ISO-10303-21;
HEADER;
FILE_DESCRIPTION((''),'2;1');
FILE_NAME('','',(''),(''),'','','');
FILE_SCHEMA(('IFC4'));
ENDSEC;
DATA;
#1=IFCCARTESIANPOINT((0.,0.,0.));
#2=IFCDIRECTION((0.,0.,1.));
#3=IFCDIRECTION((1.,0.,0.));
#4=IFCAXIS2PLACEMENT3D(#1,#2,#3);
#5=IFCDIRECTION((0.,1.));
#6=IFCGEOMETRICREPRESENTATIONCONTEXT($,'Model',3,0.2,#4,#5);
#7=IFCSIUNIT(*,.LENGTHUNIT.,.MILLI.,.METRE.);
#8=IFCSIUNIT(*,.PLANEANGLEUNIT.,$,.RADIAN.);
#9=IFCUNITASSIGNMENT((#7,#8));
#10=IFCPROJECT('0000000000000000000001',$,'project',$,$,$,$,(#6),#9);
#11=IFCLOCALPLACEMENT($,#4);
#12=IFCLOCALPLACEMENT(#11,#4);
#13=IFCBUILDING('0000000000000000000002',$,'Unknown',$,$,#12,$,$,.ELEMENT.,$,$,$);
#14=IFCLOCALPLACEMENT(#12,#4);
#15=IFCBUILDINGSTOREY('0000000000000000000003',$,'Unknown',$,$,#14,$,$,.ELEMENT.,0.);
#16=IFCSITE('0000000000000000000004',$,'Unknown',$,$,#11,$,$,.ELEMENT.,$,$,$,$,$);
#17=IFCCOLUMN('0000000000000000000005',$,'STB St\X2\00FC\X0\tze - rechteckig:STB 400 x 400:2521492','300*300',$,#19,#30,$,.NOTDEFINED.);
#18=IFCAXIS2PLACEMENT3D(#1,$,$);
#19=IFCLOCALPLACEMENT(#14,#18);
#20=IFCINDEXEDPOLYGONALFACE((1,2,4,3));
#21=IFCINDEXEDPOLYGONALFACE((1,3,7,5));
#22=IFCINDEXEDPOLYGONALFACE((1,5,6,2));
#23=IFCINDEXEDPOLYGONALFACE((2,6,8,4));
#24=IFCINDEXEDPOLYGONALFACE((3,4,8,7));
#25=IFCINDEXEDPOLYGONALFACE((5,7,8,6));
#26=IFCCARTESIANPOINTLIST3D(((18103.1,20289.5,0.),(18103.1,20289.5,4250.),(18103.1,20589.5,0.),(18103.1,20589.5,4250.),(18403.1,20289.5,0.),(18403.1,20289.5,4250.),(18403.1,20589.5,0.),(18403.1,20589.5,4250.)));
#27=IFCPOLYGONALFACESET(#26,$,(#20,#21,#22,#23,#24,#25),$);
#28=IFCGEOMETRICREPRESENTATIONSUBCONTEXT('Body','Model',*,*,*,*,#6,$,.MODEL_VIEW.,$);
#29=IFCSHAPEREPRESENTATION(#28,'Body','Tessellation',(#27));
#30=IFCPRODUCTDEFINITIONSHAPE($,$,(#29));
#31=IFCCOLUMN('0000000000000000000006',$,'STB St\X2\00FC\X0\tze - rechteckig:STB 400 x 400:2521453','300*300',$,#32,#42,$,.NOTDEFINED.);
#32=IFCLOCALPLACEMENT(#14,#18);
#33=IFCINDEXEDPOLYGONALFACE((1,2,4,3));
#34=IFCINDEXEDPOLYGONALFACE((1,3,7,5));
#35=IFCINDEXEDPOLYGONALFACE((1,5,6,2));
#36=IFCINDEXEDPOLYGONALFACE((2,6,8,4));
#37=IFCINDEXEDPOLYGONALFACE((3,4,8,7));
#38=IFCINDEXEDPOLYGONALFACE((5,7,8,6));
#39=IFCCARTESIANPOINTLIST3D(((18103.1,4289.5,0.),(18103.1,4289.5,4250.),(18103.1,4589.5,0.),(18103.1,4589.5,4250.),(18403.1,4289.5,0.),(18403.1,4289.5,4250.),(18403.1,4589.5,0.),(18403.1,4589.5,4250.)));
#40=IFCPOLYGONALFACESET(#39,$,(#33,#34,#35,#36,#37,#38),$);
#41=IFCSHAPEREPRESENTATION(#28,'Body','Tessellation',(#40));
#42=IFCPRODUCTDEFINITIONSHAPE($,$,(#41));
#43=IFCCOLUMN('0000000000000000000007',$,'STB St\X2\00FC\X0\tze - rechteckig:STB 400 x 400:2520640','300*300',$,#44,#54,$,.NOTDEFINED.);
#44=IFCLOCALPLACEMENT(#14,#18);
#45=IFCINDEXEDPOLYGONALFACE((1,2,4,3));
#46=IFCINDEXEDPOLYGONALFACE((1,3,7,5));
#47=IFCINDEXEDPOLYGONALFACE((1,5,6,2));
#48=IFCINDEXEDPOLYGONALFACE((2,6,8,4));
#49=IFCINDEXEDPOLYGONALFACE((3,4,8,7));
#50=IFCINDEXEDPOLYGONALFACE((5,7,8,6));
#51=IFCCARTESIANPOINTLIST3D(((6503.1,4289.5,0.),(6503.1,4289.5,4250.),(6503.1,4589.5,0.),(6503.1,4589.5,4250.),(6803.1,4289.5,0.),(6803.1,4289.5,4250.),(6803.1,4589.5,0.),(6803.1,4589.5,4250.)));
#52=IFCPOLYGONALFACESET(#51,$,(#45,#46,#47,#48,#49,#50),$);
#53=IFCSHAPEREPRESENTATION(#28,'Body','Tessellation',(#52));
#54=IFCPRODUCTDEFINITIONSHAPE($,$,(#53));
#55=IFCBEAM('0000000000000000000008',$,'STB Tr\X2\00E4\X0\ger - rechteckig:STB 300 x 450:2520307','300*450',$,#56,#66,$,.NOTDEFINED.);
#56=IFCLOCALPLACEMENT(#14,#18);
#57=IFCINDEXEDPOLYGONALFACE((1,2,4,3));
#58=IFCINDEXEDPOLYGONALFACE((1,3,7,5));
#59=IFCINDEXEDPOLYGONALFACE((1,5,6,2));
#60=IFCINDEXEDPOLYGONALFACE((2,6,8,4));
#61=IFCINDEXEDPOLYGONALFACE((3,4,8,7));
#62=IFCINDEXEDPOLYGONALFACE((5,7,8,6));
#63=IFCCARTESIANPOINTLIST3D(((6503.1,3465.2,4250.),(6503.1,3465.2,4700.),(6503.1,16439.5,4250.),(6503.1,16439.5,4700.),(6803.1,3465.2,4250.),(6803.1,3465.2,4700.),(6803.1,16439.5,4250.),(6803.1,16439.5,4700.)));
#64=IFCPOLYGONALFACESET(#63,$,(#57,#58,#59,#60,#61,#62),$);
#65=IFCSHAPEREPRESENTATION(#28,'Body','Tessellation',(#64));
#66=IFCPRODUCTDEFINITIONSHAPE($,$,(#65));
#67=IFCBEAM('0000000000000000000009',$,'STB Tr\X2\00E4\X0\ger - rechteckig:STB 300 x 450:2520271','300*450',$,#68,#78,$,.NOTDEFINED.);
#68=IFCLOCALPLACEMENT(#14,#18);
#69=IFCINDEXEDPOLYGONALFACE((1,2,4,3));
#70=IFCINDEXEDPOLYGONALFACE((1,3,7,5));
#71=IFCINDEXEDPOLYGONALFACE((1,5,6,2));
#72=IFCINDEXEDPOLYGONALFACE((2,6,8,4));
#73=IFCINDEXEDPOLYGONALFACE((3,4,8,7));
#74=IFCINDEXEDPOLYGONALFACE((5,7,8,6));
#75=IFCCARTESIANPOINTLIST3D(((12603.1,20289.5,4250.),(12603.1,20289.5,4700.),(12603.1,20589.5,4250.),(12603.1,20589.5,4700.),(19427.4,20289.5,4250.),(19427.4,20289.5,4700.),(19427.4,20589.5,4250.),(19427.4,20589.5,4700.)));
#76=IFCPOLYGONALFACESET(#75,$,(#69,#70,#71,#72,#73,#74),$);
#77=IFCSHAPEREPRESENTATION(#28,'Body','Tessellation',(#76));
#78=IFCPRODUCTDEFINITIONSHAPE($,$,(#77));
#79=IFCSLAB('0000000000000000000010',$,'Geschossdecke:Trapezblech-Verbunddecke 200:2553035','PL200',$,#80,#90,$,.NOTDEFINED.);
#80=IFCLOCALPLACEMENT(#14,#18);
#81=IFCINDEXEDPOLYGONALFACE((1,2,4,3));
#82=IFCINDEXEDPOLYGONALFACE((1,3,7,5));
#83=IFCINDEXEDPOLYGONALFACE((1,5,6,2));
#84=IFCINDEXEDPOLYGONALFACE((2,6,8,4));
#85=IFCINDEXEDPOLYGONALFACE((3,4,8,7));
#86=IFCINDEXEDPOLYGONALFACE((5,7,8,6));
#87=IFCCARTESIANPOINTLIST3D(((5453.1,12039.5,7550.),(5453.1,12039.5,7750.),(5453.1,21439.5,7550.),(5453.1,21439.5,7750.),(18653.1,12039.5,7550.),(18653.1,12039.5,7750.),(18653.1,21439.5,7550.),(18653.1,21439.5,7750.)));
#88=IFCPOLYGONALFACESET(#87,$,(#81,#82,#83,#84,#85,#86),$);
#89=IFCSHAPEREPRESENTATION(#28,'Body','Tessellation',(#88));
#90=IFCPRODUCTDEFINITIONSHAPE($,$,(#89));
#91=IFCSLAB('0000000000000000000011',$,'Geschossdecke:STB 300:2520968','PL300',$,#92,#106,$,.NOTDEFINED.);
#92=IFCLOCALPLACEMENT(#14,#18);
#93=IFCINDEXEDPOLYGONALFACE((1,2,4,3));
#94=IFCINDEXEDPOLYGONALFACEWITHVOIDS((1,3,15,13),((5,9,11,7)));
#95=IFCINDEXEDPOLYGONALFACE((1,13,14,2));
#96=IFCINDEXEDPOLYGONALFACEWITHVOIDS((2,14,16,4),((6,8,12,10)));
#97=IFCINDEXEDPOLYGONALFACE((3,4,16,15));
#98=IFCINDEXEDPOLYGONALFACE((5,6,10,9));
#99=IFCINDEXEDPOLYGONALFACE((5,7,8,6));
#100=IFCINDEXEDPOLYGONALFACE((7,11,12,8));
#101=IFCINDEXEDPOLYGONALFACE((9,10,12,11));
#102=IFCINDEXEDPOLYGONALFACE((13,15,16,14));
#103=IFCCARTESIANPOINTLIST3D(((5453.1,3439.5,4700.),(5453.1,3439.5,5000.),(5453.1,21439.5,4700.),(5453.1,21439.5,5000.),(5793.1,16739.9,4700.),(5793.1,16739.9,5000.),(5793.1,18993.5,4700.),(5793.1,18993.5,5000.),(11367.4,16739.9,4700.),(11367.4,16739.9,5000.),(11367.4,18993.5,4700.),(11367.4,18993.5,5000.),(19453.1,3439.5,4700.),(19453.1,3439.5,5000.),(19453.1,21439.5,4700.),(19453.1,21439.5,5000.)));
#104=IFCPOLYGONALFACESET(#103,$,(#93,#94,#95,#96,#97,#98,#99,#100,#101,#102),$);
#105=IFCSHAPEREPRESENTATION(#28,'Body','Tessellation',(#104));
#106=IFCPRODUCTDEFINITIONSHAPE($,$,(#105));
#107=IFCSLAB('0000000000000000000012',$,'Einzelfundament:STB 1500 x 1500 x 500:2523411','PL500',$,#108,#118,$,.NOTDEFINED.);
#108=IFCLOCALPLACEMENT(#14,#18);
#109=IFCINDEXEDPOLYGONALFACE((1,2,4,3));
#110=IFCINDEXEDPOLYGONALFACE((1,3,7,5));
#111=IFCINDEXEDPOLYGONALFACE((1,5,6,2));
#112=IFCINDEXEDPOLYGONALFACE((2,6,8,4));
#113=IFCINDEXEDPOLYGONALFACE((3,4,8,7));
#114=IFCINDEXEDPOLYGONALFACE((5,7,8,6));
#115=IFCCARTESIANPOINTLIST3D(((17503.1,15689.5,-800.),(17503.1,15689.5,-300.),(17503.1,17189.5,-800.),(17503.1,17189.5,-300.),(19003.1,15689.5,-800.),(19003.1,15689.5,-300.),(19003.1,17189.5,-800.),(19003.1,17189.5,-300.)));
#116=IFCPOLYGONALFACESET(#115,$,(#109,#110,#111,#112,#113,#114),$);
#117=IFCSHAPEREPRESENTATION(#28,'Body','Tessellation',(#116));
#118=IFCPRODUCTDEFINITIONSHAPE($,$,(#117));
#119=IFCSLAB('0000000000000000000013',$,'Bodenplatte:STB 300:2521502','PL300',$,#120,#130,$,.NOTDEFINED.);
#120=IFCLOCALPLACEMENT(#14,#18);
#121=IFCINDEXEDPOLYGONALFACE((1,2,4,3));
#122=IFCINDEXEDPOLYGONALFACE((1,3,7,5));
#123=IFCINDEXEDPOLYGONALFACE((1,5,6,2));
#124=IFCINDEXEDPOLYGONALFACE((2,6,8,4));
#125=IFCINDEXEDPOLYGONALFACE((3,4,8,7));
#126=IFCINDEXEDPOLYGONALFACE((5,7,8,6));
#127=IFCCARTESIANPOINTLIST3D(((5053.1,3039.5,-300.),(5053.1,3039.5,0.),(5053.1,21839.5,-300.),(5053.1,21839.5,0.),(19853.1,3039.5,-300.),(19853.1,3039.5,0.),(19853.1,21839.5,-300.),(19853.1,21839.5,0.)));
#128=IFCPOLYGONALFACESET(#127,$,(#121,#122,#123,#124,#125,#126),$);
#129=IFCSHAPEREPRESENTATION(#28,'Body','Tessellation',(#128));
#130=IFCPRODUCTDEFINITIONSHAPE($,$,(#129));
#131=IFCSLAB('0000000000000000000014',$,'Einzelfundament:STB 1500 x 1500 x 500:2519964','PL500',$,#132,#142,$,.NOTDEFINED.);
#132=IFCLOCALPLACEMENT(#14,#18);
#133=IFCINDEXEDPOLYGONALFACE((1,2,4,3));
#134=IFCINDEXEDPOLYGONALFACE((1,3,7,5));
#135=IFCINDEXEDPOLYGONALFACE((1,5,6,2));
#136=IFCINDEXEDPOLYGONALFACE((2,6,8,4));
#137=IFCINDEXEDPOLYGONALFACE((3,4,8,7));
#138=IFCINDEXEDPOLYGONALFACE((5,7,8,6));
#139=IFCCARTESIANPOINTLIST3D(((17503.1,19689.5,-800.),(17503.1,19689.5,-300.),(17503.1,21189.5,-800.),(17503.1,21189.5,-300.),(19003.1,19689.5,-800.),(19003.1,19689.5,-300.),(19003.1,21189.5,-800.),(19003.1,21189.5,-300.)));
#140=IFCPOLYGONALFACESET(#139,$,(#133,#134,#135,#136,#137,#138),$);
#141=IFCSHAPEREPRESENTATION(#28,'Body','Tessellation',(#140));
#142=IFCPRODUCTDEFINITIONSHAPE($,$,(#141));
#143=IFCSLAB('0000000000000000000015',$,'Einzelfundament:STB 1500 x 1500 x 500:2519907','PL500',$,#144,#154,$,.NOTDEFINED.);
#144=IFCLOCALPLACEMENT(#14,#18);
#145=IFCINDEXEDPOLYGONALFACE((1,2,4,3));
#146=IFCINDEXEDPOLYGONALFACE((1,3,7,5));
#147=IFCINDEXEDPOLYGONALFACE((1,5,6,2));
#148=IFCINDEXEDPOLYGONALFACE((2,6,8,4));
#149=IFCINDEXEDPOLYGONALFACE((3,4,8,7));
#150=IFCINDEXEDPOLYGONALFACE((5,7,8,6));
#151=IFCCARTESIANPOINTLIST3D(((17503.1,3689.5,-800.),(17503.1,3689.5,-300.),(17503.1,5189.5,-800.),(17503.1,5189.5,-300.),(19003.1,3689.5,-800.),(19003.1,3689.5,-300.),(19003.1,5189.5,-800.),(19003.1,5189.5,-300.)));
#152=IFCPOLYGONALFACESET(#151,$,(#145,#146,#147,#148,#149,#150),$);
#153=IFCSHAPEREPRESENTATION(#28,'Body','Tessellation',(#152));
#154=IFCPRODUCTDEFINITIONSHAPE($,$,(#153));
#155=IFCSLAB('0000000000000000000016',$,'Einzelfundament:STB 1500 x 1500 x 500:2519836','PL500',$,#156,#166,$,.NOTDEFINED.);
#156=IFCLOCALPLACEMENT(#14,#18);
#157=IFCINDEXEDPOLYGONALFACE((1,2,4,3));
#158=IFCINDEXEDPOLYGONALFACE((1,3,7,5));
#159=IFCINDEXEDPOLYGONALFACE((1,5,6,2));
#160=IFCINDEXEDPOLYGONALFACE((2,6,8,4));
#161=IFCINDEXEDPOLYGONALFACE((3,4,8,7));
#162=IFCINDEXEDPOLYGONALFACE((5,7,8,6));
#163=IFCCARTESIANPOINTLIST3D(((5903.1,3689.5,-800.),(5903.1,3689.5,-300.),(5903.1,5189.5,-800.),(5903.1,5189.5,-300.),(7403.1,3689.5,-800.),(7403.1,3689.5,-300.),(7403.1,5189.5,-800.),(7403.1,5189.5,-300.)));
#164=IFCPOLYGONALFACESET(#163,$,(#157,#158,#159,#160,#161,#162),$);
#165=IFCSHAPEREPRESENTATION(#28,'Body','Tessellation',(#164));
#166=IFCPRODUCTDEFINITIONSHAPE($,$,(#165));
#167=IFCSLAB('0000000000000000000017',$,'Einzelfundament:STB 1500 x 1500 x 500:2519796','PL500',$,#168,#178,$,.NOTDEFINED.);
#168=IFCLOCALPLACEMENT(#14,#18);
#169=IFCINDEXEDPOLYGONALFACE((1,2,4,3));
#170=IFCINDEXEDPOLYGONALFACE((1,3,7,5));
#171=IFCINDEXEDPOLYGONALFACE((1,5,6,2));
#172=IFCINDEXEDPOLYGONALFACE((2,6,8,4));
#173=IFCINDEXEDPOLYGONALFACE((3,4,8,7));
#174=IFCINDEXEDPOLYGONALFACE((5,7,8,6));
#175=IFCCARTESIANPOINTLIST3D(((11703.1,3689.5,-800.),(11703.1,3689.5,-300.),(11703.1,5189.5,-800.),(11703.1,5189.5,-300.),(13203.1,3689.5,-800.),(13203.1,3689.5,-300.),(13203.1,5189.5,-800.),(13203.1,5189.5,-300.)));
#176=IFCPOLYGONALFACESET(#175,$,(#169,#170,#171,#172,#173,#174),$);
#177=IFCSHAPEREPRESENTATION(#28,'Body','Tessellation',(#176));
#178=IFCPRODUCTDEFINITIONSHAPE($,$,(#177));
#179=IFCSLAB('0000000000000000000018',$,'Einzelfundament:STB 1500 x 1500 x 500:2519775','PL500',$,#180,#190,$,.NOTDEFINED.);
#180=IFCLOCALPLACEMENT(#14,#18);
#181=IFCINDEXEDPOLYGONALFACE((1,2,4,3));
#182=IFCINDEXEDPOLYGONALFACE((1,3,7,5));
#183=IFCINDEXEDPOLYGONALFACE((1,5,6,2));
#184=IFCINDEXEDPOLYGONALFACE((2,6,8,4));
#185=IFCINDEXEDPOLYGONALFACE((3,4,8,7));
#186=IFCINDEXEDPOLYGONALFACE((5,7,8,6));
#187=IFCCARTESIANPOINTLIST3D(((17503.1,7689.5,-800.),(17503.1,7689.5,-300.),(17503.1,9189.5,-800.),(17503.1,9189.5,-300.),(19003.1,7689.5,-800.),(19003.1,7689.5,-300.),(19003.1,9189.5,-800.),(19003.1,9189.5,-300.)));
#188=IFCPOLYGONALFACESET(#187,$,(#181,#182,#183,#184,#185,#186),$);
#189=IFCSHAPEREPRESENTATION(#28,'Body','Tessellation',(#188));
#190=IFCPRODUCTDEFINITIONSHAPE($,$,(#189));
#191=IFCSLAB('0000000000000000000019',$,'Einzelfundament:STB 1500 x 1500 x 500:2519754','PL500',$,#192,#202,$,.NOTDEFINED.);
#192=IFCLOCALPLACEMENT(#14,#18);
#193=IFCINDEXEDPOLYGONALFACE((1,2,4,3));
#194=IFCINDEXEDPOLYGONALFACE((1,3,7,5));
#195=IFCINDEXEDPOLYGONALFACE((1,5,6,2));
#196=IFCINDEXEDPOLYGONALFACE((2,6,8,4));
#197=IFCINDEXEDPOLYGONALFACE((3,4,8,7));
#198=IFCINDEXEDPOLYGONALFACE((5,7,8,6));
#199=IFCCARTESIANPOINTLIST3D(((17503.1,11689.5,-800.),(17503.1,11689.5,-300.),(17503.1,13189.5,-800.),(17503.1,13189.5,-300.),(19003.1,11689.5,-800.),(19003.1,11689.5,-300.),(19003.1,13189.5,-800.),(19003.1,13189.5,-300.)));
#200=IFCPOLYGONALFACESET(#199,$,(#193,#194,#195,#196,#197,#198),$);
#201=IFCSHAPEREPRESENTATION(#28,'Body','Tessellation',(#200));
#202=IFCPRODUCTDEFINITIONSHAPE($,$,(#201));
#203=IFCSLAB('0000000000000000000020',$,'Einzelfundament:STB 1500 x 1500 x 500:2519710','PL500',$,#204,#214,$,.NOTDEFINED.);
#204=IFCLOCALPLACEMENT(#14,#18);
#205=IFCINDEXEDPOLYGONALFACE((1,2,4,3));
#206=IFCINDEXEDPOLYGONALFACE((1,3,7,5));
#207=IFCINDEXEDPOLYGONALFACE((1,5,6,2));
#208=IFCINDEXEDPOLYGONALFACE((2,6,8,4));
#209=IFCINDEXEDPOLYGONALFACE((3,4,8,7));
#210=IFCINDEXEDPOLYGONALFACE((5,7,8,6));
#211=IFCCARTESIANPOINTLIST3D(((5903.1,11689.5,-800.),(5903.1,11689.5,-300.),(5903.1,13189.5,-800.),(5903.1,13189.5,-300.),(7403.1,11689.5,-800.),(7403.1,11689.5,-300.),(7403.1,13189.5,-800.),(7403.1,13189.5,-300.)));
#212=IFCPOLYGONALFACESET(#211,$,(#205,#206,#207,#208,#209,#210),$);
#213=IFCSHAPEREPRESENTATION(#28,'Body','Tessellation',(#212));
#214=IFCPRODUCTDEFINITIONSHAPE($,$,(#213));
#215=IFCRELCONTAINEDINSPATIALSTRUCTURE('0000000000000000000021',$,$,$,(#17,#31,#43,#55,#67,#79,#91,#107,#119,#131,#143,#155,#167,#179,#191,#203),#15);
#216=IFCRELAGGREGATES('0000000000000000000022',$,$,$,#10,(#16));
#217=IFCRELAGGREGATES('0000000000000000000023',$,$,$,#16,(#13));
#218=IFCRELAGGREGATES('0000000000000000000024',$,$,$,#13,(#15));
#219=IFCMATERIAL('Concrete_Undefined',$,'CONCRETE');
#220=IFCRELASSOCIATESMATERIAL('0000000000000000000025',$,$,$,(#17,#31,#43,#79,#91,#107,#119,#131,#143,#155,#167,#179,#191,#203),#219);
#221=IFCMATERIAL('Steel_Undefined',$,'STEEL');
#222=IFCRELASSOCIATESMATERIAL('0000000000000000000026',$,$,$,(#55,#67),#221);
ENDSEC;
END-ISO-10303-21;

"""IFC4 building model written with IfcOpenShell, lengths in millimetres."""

from ifc_helpers import new_model, si_unit, direction, frame, origin_with_axes, place, context, subcontext, project, spatial, line, indexed_curve, outline, extrude, material, element, save


model = new_model("IFC4")

# Units and contexts
model_context = context("Model", 3, precision=0.2, world=origin_with_axes(), true_north=direction((0.0, 1.0)))
body_context = subcontext(model_context, "Body", "Model", "MODEL_VIEW")
ifc_project = project(units=[si_unit("LENGTHUNIT", "METRE", prefix="MILLI"), si_unit("PLANEANGLEUNIT", "RADIAN")], contexts=[model_context])

# Site, building, storey
site_placement = place(None, origin_with_axes())
site = spatial("IfcSite", under=ifc_project, at=site_placement, Name="Unknown", CompositionType="ELEMENT")
building_placement = place(site_placement, origin_with_axes())
building = spatial("IfcBuilding", under=site, at=building_placement, Name="Unknown", CompositionType="ELEMENT")
storey_placement = place(building_placement, origin_with_axes())
storey = spatial("IfcBuildingStorey", under=building, at=storey_placement, Name="Unknown", CompositionType="ELEMENT", Elevation=0.0)

# Columns
ifc_material_1 = material(Name="Concrete_Undefined", Category="CONCRETE")
for number, where, z_axis, x_axis, name in (
    (1, (18253.1, 20439.5, 0.0), (1.0, 0.0, 0.0), (0.0, 0.0, 1.0), "STB Stütze - rechteckig:STB 400 x 400:2521492"),
    (2, (18253.1, 4439.5, 0.0), (1.0, 0.0, 0.0), (0.0, 0.0, 1.0), "STB Stütze - rechteckig:STB 400 x 400:2521453"),
    (3, (6653.1, 4439.5, 0.0), (1.0, 0.0, 0.0), (0.0, 0.0, 1.0), "STB Stütze - rechteckig:STB 400 x 400:2520640"),
):
    element("IfcColumn", number, at=place(storey_placement, frame(where, z_axis=z_axis, x_axis=x_axis)), inside=storey, material=ifc_material_1, Name=name, Description="300*300", PredefinedType="NOTDEFINED", context=body_context, shape_type="SolidModel", body=[
        extrude(outline(indexed_curve([(-150.0, -150.0), (150.0, -150.0), (150.0, 150.0), (-150.0, 150.0)], segments=[line(1, 2, 3, 4, 1)])), frame((0.0, 0.0, 0.0), z_axis=(-1.0, 0.0, 0.0), x_axis=(0.0, 0.0, 1.0)), (0.0, 0.0, -1.0), 4250.0),
    ])

# Beams
ifc_material_2 = material(Name="Steel_Undefined", Category="STEEL")
beam_1_placement = place(storey_placement, frame((6653.1, 16439.5, 4475.0), z_axis=(0.0, 0.0, 1.0), x_axis=(0.0, -1.0, 0.0)))
element("IfcBeam", 4, at=beam_1_placement, inside=storey, material=ifc_material_2, Name="STB Träger - rechteckig:STB 300 x 450:2520307", Description="300*450", PredefinedType="NOTDEFINED", context=body_context, shape_type="SolidModel", body=[
    extrude(outline(indexed_curve([(-225.0, -150.0), (225.0, -150.0), (225.0, 150.0), (-225.0, 150.0)], segments=[line(1, 2, 3, 4, 1)])), frame((0.0, 0.0, 0.0), z_axis=(-1.0, 0.0, 0.0), x_axis=(0.0, 0.0, 1.0)), (0.0, 0.0, -1.0), 12974.3),
])
beam_2_placement = place(storey_placement, frame((12603.1, 20439.5, 4475.0), z_axis=(0.0, 0.0, 1.0), x_axis=(1.0, 0.0, 0.0)))
element("IfcBeam", 5, at=beam_2_placement, inside=storey, material=ifc_material_2, Name="STB Träger - rechteckig:STB 300 x 450:2520271", Description="300*450", PredefinedType="NOTDEFINED", context=body_context, shape_type="SolidModel", body=[
    extrude(outline(indexed_curve([(-225.0, -150.0), (225.0, -150.0), (225.0, 150.0), (-225.0, 150.0)], segments=[line(1, 2, 3, 4, 1)])), frame((0.0, 0.0, 0.0), z_axis=(-1.0, 0.0, 0.0), x_axis=(0.0, 0.0, 1.0)), (0.0, 0.0, -1.0), 6824.3),
])

# Slab
slab_1_placement = place(storey_placement, frame((5453.1, 21439.5, 7650.0), z_axis=(0.0, 0.0, 1.0), x_axis=(0.0, -1.0, 0.0)))
element("IfcSlab", 6, at=slab_1_placement, inside=storey, material=ifc_material_1, Name="Geschossdecke:Trapezblech-Verbunddecke 200:2553035", Description="PL200", PredefinedType="NOTDEFINED", context=body_context, shape_type="SolidModel", body=[
    extrude(outline(indexed_curve([(0.0, 0.0), (9400.0, 0.0), (9400.0, 13200.0), (0.0, 13200.0)], segments=[line(1, 2, 3, 4, 1)])), frame((0.0, 0.0, 100.0), z_axis=(0.0, 0.0, 1.0), x_axis=(1.0, 0.0, 0.0)), (0.0, 0.0, -1.0), 200.0),
])

# Slab, voiding feature
slab_2_placement = place(storey_placement, frame((19453.1, 3439.5, 4850.0), z_axis=(0.0, 0.0, 1.0), x_axis=(0.0, 1.0, 0.0)))
slab_2 = element("IfcSlab", 7, at=slab_2_placement, inside=storey, material=ifc_material_1, Name="Geschossdecke:STB 300:2520968", Description="PL300", PredefinedType="NOTDEFINED", context=body_context, shape_type="SolidModel", body=[
    extrude(outline(indexed_curve([(0.0, 0.0), (18000.0, 0.0), (18000.0, 14000.0), (0.0, 14000.0)], segments=[line(1, 2, 3, 4, 1)])), frame((0.0, 0.0, 150.0), z_axis=(0.0, 0.0, 1.0), x_axis=(1.0, 0.0, 0.0)), (0.0, 0.0, -1.0), 300.0),
])
voiding_feature_placement = place(slab_2_placement, frame((14427.2, 10872.8, 150.0), z_axis=(-1.0, 0.0, 0.0), x_axis=(0.0, 0.0, -1.0)))
element("IfcVoidingFeature", 8, at=voiding_feature_placement, cuts=slab_2, Name="Geschossdecke:STB 300:712247", PredefinedType="HOLE", context=body_context, shape_type="SolidModel", body=[
    extrude(outline(indexed_curve([(-1126.8, -2787.2), (1126.8, -2787.2), (1126.8, 2787.2), (-1126.8, 2787.2)], segments=[line(1, 2, 3, 4, 1)])), frame((0.0, 0.0, 0.0), z_axis=(-1.0, 0.0, 0.0), x_axis=(0.0, 0.0, 1.0)), (0.0, 0.0, -1.0), 300.0),
])

# Slabs
slab_3_placement = place(storey_placement, frame((17503.1, 17189.5, -550.0), z_axis=(0.0, 0.0, -1.0), x_axis=(1.0, 0.0, 0.0)))
element("IfcSlab", 9, at=slab_3_placement, inside=storey, material=ifc_material_1, Name="Einzelfundament:STB 1500 x 1500 x 500:2523411", Description="PL500", PredefinedType="NOTDEFINED", context=body_context, shape_type="SolidModel", body=[
    extrude(outline(indexed_curve([(0.0, 0.0), (1500.0, 0.0), (1500.0, 1500.0), (0.0, 1500.0)], segments=[line(1, 2, 3, 4, 1)])), frame((0.0, 0.0, 250.0), z_axis=(0.0, 0.0, 1.0), x_axis=(1.0, 0.0, 0.0)), (0.0, 0.0, -1.0), 500.0),
])
slab_4_placement = place(storey_placement, frame((5053.1, 21839.5, -150.0), z_axis=(0.0, 0.0, 1.0), x_axis=(0.0, -1.0, 0.0)))
element("IfcSlab", 10, at=slab_4_placement, inside=storey, material=ifc_material_1, Name="Bodenplatte:STB 300:2521502", Description="PL300", PredefinedType="NOTDEFINED", context=body_context, shape_type="SolidModel", body=[
    extrude(outline(indexed_curve([(0.0, 0.0), (18800.0, 0.0), (18800.0, 14800.0), (0.0, 14800.0)], segments=[line(1, 2, 3, 4, 1)])), frame((0.0, 0.0, 150.0), z_axis=(0.0, 0.0, 1.0), x_axis=(1.0, 0.0, 0.0)), (0.0, 0.0, -1.0), 300.0),
])
for number, where, z_axis, x_axis, name in (
    (11, (17503.1, 21189.5, -550.0), (0.0, 0.0, -1.0), (1.0, 0.0, 0.0), "Einzelfundament:STB 1500 x 1500 x 500:2519964"),
    (12, (17503.1, 5189.5, -550.0), (0.0, 0.0, -1.0), (1.0, 0.0, 0.0), "Einzelfundament:STB 1500 x 1500 x 500:2519907"),
    (13, (5903.1, 5189.5, -550.0), (0.0, 0.0, -1.0), (1.0, 0.0, 0.0), "Einzelfundament:STB 1500 x 1500 x 500:2519836"),
    (14, (13203.1, 5189.5, -550.0), (0.0, 0.0, -1.0), (0.0, -1.0, 0.0), "Einzelfundament:STB 1500 x 1500 x 500:2519796"),
    (15, (17503.1, 9189.5, -550.0), (0.0, 0.0, -1.0), (1.0, 0.0, 0.0), "Einzelfundament:STB 1500 x 1500 x 500:2519775"),
    (16, (17503.1, 13189.5, -550.0), (0.0, 0.0, -1.0), (1.0, 0.0, 0.0), "Einzelfundament:STB 1500 x 1500 x 500:2519754"),
    (17, (5903.1, 13189.5, -550.0), (0.0, 0.0, -1.0), (1.0, 0.0, 0.0), "Einzelfundament:STB 1500 x 1500 x 500:2519710"),
):
    element("IfcSlab", number, at=place(storey_placement, frame(where, z_axis=z_axis, x_axis=x_axis)), inside=storey, material=ifc_material_1, Name=name, Description="PL500", PredefinedType="NOTDEFINED", context=body_context, shape_type="SolidModel", body=[
        extrude(outline(indexed_curve([(0.0, 0.0), (1500.0, 0.0), (1500.0, 1500.0), (0.0, 1500.0)], segments=[line(1, 2, 3, 4, 1)])), frame((0.0, 0.0, 250.0), z_axis=(0.0, 0.0, 1.0), x_axis=(1.0, 0.0, 0.0)), (0.0, 0.0, -1.0), 500.0),
    ])

save(model, "model.ifc")
